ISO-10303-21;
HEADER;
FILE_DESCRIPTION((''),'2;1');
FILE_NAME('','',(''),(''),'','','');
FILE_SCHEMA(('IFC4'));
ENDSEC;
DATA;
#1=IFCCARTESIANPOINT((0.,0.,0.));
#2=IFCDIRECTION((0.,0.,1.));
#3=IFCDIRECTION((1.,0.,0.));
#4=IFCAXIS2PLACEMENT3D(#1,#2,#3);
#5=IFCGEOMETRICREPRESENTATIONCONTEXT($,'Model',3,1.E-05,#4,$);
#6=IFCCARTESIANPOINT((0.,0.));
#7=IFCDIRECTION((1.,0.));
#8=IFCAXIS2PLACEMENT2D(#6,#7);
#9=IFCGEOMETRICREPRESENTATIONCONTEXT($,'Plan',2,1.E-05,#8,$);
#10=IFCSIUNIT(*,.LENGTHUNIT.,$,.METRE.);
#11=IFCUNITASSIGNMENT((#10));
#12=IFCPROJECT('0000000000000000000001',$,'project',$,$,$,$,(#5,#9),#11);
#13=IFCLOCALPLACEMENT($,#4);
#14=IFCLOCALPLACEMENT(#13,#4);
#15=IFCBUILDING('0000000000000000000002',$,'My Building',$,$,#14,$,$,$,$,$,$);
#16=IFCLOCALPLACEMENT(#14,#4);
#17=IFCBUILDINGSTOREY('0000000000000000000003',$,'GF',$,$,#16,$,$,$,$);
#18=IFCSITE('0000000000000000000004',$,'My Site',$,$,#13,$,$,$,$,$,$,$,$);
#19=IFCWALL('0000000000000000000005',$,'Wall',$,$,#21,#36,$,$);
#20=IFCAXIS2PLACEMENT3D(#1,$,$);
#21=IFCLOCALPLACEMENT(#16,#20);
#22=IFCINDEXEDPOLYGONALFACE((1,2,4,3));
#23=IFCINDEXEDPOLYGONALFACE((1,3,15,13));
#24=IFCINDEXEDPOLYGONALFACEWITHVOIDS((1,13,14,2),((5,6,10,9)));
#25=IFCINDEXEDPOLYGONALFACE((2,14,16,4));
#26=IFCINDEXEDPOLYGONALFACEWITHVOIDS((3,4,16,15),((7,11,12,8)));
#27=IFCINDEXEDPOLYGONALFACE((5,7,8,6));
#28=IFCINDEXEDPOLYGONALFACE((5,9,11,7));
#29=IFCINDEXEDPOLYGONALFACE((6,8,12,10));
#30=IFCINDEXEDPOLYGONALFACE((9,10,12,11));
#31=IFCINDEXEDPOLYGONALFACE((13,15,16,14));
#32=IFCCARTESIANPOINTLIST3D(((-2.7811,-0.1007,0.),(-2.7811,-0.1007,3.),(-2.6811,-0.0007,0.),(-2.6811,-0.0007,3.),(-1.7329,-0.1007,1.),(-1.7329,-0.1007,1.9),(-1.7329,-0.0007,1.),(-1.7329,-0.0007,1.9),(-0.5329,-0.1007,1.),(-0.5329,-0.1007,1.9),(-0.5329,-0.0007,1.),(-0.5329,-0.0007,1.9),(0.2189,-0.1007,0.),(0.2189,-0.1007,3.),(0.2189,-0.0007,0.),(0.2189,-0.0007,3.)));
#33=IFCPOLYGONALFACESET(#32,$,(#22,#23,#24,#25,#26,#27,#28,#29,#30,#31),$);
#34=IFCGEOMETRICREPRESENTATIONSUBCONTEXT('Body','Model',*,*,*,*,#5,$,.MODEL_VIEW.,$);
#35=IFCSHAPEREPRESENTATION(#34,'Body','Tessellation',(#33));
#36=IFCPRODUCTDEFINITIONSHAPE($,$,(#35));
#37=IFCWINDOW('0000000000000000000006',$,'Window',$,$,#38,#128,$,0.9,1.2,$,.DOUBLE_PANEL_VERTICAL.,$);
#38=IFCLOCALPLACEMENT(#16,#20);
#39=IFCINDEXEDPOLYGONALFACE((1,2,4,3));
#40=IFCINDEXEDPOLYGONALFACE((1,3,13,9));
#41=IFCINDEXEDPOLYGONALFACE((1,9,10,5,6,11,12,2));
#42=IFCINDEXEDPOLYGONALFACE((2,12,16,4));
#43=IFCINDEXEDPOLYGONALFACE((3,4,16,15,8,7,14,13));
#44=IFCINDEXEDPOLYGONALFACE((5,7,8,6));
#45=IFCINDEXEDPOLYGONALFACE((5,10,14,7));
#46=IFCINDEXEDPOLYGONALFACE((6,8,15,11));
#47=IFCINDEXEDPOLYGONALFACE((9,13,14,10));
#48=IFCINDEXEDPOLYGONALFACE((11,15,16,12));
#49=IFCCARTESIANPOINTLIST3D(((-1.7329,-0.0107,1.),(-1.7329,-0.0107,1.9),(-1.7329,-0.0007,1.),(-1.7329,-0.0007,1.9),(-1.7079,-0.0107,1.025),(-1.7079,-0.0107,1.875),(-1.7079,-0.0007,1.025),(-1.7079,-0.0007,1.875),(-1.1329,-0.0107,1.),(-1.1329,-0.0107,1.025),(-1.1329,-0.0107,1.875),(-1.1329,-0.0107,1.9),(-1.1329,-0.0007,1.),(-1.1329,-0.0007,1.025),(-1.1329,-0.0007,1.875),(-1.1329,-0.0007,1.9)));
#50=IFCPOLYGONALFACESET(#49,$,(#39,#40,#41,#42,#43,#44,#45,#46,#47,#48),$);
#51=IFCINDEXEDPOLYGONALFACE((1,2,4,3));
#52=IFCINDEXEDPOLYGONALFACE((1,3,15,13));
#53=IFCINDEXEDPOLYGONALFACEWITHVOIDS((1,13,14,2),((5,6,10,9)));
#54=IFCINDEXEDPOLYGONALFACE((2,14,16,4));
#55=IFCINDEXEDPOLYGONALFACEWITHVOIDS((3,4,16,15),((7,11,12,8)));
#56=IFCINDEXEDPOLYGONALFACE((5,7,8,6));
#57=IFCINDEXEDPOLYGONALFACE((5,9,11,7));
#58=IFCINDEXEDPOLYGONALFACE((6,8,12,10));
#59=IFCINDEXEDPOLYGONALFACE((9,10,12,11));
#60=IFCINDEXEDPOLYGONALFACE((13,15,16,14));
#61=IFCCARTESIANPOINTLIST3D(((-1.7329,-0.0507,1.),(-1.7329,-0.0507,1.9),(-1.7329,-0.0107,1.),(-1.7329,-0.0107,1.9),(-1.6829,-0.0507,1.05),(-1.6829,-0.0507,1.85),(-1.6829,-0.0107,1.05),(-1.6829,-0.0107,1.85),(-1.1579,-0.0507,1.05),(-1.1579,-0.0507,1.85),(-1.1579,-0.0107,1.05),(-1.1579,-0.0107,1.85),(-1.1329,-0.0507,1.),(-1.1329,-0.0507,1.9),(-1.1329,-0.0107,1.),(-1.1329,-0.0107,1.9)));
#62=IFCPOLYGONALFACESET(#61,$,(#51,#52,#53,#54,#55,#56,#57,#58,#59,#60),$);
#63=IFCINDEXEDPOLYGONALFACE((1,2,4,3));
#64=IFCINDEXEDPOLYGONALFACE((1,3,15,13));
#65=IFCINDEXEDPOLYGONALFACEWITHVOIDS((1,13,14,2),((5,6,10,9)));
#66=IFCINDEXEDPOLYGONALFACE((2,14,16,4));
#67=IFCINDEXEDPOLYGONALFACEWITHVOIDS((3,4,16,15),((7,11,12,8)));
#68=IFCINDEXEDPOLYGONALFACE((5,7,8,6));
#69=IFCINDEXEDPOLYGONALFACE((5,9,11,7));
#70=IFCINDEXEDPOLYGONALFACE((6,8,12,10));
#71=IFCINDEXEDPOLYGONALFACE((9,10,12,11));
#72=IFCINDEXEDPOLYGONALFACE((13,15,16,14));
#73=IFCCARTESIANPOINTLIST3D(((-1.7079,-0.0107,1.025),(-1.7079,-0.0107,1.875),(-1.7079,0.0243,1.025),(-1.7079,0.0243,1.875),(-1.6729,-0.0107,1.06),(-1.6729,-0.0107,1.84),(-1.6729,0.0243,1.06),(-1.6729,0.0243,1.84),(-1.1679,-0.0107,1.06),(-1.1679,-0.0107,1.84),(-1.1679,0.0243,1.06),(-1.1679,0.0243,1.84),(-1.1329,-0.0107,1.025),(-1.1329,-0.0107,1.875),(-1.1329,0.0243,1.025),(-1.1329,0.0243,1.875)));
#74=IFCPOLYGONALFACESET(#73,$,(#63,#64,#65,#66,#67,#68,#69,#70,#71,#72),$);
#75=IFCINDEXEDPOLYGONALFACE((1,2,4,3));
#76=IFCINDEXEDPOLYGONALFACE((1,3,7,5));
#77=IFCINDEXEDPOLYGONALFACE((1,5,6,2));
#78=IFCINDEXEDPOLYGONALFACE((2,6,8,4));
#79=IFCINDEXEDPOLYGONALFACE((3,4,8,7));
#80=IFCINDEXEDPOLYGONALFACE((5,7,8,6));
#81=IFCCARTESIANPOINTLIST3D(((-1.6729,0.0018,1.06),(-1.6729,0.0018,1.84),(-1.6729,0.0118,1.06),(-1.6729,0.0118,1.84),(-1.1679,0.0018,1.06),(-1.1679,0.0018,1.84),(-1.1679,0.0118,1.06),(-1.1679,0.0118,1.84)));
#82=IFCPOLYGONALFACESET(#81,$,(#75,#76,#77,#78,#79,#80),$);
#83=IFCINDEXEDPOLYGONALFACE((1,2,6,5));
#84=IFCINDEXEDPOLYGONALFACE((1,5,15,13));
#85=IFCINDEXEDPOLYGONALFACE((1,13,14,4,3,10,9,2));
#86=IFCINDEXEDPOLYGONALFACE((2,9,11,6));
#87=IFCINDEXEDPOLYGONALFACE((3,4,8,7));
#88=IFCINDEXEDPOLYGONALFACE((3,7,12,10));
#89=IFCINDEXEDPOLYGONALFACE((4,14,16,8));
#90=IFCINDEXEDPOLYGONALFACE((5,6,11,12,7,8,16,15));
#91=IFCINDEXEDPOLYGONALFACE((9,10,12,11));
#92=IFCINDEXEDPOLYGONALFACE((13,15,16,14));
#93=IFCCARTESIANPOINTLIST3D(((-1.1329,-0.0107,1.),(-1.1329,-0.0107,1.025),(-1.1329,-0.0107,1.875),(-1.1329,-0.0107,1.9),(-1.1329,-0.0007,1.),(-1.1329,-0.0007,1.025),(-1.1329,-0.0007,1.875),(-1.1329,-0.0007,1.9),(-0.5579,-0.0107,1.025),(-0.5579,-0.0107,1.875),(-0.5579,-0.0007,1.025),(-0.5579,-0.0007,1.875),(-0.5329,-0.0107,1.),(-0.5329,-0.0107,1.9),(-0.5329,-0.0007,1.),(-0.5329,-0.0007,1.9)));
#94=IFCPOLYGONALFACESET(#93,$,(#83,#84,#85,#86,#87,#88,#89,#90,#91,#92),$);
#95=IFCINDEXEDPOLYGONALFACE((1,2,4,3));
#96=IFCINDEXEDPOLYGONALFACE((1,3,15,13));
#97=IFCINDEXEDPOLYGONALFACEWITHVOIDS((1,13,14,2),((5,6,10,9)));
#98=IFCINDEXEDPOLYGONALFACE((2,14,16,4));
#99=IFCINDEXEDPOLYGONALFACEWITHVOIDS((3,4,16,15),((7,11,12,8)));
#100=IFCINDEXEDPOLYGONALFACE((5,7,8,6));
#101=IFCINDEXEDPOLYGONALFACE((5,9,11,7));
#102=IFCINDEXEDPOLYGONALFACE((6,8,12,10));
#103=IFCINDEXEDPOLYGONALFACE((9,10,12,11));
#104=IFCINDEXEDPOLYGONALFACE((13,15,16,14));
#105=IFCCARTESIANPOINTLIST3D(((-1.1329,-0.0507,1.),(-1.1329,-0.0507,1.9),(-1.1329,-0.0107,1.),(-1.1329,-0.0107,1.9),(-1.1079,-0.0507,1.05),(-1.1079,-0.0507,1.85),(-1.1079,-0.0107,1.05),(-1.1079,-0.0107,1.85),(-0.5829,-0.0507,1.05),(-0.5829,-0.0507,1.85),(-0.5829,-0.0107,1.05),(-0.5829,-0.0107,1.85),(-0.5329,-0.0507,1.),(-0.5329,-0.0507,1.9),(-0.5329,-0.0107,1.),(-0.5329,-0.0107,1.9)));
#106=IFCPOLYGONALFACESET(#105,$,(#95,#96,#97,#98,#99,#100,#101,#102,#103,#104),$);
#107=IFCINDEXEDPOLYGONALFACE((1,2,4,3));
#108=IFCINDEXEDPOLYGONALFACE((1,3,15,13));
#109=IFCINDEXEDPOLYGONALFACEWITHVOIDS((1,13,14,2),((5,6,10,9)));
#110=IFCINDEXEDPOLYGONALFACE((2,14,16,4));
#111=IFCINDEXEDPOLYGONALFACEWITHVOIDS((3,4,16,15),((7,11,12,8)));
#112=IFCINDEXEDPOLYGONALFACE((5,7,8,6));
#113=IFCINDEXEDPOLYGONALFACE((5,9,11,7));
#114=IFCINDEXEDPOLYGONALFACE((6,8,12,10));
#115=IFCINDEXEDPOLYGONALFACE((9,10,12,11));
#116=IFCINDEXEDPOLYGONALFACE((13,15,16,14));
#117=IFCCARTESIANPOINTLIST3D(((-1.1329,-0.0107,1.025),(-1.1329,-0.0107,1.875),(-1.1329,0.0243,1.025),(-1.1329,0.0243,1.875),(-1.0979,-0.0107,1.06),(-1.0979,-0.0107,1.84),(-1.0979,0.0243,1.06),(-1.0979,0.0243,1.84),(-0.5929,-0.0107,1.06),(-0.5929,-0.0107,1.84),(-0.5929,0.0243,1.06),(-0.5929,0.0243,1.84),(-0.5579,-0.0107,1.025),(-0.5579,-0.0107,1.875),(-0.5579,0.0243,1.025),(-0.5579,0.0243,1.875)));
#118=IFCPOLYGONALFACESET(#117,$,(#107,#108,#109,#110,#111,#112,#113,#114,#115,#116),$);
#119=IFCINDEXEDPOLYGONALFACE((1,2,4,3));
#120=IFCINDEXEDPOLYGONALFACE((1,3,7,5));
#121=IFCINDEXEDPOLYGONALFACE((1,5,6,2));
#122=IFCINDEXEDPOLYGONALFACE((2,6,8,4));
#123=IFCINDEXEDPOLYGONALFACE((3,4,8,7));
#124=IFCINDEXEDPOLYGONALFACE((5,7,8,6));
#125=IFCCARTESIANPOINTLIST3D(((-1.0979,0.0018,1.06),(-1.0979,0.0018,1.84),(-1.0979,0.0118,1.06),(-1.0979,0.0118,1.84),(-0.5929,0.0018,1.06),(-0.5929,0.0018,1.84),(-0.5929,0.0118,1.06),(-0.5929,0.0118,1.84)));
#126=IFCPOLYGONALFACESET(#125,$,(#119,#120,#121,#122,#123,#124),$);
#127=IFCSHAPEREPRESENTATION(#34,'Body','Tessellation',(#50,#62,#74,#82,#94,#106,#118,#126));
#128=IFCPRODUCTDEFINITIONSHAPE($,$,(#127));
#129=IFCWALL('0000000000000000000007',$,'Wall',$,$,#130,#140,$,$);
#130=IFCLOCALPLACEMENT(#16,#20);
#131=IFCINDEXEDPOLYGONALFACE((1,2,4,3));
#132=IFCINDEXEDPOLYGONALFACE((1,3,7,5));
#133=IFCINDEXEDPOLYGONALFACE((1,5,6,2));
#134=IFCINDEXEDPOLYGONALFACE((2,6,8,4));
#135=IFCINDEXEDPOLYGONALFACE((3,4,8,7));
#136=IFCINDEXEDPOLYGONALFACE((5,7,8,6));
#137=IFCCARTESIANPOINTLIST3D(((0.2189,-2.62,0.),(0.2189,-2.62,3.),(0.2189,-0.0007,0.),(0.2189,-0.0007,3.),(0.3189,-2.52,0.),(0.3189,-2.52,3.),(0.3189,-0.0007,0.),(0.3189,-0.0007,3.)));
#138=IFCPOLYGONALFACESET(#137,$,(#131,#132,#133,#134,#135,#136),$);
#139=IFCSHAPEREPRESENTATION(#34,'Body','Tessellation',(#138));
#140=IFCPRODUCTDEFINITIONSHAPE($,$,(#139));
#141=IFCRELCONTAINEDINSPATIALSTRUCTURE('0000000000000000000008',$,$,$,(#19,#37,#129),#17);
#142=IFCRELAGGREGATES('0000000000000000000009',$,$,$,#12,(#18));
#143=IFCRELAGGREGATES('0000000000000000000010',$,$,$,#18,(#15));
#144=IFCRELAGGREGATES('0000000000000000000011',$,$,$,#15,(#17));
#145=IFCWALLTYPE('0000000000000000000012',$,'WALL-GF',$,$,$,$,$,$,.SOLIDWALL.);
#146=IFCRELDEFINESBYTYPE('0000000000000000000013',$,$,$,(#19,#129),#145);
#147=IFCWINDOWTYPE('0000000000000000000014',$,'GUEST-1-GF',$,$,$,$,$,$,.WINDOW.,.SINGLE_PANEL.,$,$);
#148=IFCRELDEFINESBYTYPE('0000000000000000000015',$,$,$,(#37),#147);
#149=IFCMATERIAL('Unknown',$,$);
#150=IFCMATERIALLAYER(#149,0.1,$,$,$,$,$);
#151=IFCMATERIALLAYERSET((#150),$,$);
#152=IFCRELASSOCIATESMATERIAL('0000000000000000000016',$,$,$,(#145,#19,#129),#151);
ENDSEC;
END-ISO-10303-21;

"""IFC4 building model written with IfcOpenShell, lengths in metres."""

from ifc_helpers import new_model, entity, si_unit, frame, origin_with_axes, origin_2d_with_axis, place, context, subcontext, project, spatial, line, indexed_curve, outline, extrude, shape, source, transform, mapped, material, layer, layer_set, layer_usage, type_object, type_shapes, element, fill, save


model = new_model("IFC4")

# Units and contexts
model_context = context("Model", 3, precision=1e-05, world=origin_with_axes())
plan_context = context("Plan", 2, precision=1e-05, world=origin_2d_with_axis())
body_context_1 = subcontext(model_context, "Body", "Model", "MODEL_VIEW")
body_context_2 = subcontext(plan_context, "Body", "Plan", "PLAN_VIEW")
ifc_project = project(units=[si_unit("LENGTHUNIT", "METRE")], contexts=[model_context, plan_context])

# Site, building, storey
site_placement = place(None, origin_with_axes())
site = spatial("IfcSite", under=ifc_project, at=site_placement, Name="My Site")
building_placement = place(site_placement, origin_with_axes())
building = spatial("IfcBuilding", under=site, at=building_placement, Name="My Building")
storey_placement = place(building_placement, origin_with_axes())
storey = spatial("IfcBuildingStorey", under=building, at=storey_placement, Name="GF")

# Shared definitions
ifc_material = material(Name="Unknown")

# Shared definitions
ifc_layer_1 = layer(ifc_material, 0.1)
ifc_layer_set_1 = layer_set([ifc_layer_1])
wall_type = type_object("IfcWallType", Name="WALL-GF", PredefinedType="SOLIDWALL", material=ifc_layer_set_1)

# Wall, opening, window
ifc_layer_usage_1 = layer_usage(ifc_layer_set_1, "AXIS2", "POSITIVE", 0.0)
wall_1_placement = place(storey_placement, frame((-2.7811, -0.1007, 0.0), z_axis=(0.0, 0.0, 1.0), x_axis=(1.0, 0.0, 0.0)))
wall_1 = element("IfcWall", 1, at=wall_1_placement, inside=storey, type_object=wall_type, material=ifc_layer_usage_1, Name="Wall", context=body_context_1, shape_type="SweptSolid", body=[
    extrude(outline(indexed_curve([(0.0, 0.0), (0.1, 0.1), (3.0, 0.1), (3.0, 0.0)], segments=[line(1, 2, 3, 4, 1)])), origin_with_axes(), (0.0, 0.0, 1.0), 3.0),
])
shared_shape_1 = source(origin_with_axes(), body_context_1, "Body", "SweptSolid", [
    extrude(outline(indexed_curve([(0.0, 0.0), (1.2, 0.0), (1.2, 0.9), (0.0, 0.9)], segments=[line(1, 2, 3, 4, 1)])), frame((0.0, -0.6, 0.0), z_axis=(0.0, -1.0, 0.0), x_axis=(1.0, 0.0, 0.0)), (0.0, 0.0, -1.0), 1.2),
])
opening_1_placement = place(wall_1_placement, frame((1.0481, 0.0, 1.0), z_axis=(0.0, 0.0, 1.0), x_axis=(1.0, 0.0, 0.0)))
opening_1 = element("IfcOpeningElement", 2, at=opening_1_placement, cuts=wall_1, PredefinedType="OPENING", context=body_context_1, shape_type="MappedRepresentation", body=[
    mapped(shared_shape_1, transform((0.0, 0.0, 0.0), x_axis=(1.0, 0.0, 0.0), y_axis=(0.0, 1.0, 0.0), z_axis=(0.0, 0.0, 1.0), scale=1.0)),
])
window_type_1 = type_object("IfcWindowType", Name="GUEST-1-GF", PartitioningType="SINGLE_PANEL", PredefinedType="WINDOW")
shared_shape_2 = source(origin_with_axes(), body_context_1, "Body", "SweptSolid", [
    extrude(outline(indexed_curve([(0.6, 0.0), (0.0, 0.0), (0.0, 0.9), (0.6, 0.9), (0.6, 0.875), (0.025, 0.875), (0.025, 0.025), (0.6, 0.025)], segments=[line(1, 2, 3, 4, 5, 6, 7, 8, 1)])), frame((0.0, 0.09, 0.0), z_axis=(0.0, -1.0, 0.0), x_axis=(1.0, 0.0, 0.0)), (0.0, 0.0, -1.0), 0.01),
    extrude(outline(indexed_curve([(0.0, 0.0), (0.6, 0.0), (0.6, 0.9), (0.0, 0.9)], segments=[line(1, 2, 3, 4, 1)]), holes=[indexed_curve([(0.05, 0.05), (0.575, 0.05), (0.575, 0.85), (0.05, 0.85)], segments=[line(1, 2, 3, 4, 1)])]), frame((0.0, 0.05, 0.0), z_axis=(0.0, -1.0, 0.0), x_axis=(1.0, 0.0, 0.0)), (0.0, 0.0, -1.0), 0.04),
    extrude(outline(indexed_curve([(0.0, 0.0), (0.575, 0.0), (0.575, 0.85), (0.0, 0.85)], segments=[line(1, 2, 3, 4, 1)]), holes=[indexed_curve([(0.035, 0.035), (0.54, 0.035), (0.54, 0.815), (0.035, 0.815)], segments=[line(1, 2, 3, 4, 1)])]), frame((0.025, 0.09, 0.025), z_axis=(0.0, -1.0, 0.0), x_axis=(1.0, 0.0, 0.0)), (0.0, 0.0, -1.0), 0.035),
    extrude(outline(indexed_curve([(0.035, 0.035), (0.54, 0.035), (0.54, 0.815), (0.035, 0.815)], segments=[line(1, 2, 3, 4, 1)])), frame((0.025, 0.1025, 0.025), z_axis=(0.0, -1.0, 0.0), x_axis=(1.0, 0.0, 0.0)), (0.0, 0.0, -1.0), 0.01),
    extrude(outline(indexed_curve([(0.0, 0.9), (0.6, 0.9), (0.6, 0.0), (0.0, 0.0), (0.0, 0.025), (0.575, 0.025), (0.575, 0.875), (0.0, 0.875)], segments=[line(1, 2, 3, 4, 5, 6, 7, 8, 1)])), frame((0.6, 0.09, 0.0), z_axis=(0.0, -1.0, 0.0), x_axis=(1.0, 0.0, 0.0)), (0.0, 0.0, -1.0), 0.01),
    extrude(outline(indexed_curve([(0.0, 0.0), (0.6, 0.0), (0.6, 0.9), (0.0, 0.9)], segments=[line(1, 2, 3, 4, 1)]), holes=[indexed_curve([(0.025, 0.05), (0.55, 0.05), (0.55, 0.85), (0.025, 0.85)], segments=[line(1, 2, 3, 4, 1)])]), frame((0.6, 0.05, 0.0), z_axis=(0.0, -1.0, 0.0), x_axis=(1.0, 0.0, 0.0)), (0.0, 0.0, -1.0), 0.04),
    extrude(outline(indexed_curve([(0.0, 0.0), (0.575, 0.0), (0.575, 0.85), (0.0, 0.85)], segments=[line(1, 2, 3, 4, 1)]), holes=[indexed_curve([(0.035, 0.035), (0.54, 0.035), (0.54, 0.815), (0.035, 0.815)], segments=[line(1, 2, 3, 4, 1)])]), frame((0.6, 0.09, 0.025), z_axis=(0.0, -1.0, 0.0), x_axis=(1.0, 0.0, 0.0)), (0.0, 0.0, -1.0), 0.035),
    extrude(outline(indexed_curve([(0.035, 0.035), (0.54, 0.035), (0.54, 0.815), (0.035, 0.815)], segments=[line(1, 2, 3, 4, 1)])), frame((0.6, 0.1025, 0.025), z_axis=(0.0, -1.0, 0.0), x_axis=(1.0, 0.0, 0.0)), (0.0, 0.0, -1.0), 0.01),
])
shared_shape_3 = source(origin_with_axes(), body_context_2, "Body", "Curve2D", [
    entity("IfcIndexedPolyCurve", entity("IfcCartesianPointList2D", [[0.05, 0.05], [0.575, 0.05]])),
    entity("IfcIndexedPolyCurve", entity("IfcCartesianPointList2D", [[0.0, 0.1], [0.025, 0.1], [0.025, 0.09], [0.05, 0.09], [0.05, 0.05], [0.0, 0.05]]), [entity("IfcLineIndex", [1, 2, 3, 4, 5, 6, 1])]),
    entity("IfcIndexedPolyCurve", entity("IfcCartesianPointList2D", [[0.6, 0.1], [0.6, 0.1], [0.6, 0.09], [0.575, 0.09], [0.575, 0.05], [0.6, 0.05]])),
    entity("IfcIndexedPolyCurve", entity("IfcCartesianPointList2D", [[0.025, 0.09], [0.06, 0.09], [0.06, 0.125], [0.025, 0.125]]), [entity("IfcLineIndex", [1, 2, 3, 4, 1])]),
    entity("IfcIndexedPolyCurve", entity("IfcCartesianPointList2D", [[0.6, 0.09], [0.565, 0.09], [0.565, 0.125], [0.6, 0.125]]), [entity("IfcLineIndex", [1, 2, 3, 4, 1])]),
    entity("IfcIndexedPolyCurve", entity("IfcCartesianPointList2D", [[0.06, 0.09], [0.565, 0.09]])),
    entity("IfcIndexedPolyCurve", entity("IfcCartesianPointList2D", [[0.06, 0.125], [0.565, 0.125]])),
    entity("IfcIndexedPolyCurve", entity("IfcCartesianPointList2D", [[0.06, 0.1075], [0.565, 0.1075]])),
    entity("IfcIndexedPolyCurve", entity("IfcCartesianPointList2D", [[0.625, 0.05], [1.15, 0.05]])),
    entity("IfcIndexedPolyCurve", entity("IfcCartesianPointList2D", [[0.6, 0.1], [0.6, 0.1], [0.6, 0.09], [0.625, 0.09], [0.625, 0.05], [0.6, 0.05]])),
    entity("IfcIndexedPolyCurve", entity("IfcCartesianPointList2D", [[1.2, 0.1], [1.175, 0.1], [1.175, 0.09], [1.15, 0.09], [1.15, 0.05], [1.2, 0.05]]), [entity("IfcLineIndex", [1, 2, 3, 4, 5, 6, 1])]),
    entity("IfcIndexedPolyCurve", entity("IfcCartesianPointList2D", [[0.6, 0.09], [0.635, 0.09], [0.635, 0.125], [0.6, 0.125]]), [entity("IfcLineIndex", [1, 2, 3, 4, 1])]),
    entity("IfcIndexedPolyCurve", entity("IfcCartesianPointList2D", [[1.175, 0.09], [1.14, 0.09], [1.14, 0.125], [1.175, 0.125]]), [entity("IfcLineIndex", [1, 2, 3, 4, 1])]),
    entity("IfcIndexedPolyCurve", entity("IfcCartesianPointList2D", [[0.635, 0.09], [1.14, 0.09]])),
    entity("IfcIndexedPolyCurve", entity("IfcCartesianPointList2D", [[0.635, 0.125], [1.14, 0.125]])),
    entity("IfcIndexedPolyCurve", entity("IfcCartesianPointList2D", [[0.635, 0.1075], [1.14, 0.1075]])),
])
type_shapes(window_type_1, [shared_shape_2, shared_shape_3])
window_1_placement = place(opening_1_placement, origin_with_axes())
window_1 = element("IfcWindow", 3, at=window_1_placement, inside=storey, type_object=window_type_1, Name="Window", OverallHeight=0.9, OverallWidth=1.2, PartitioningType="DOUBLE_PANEL_VERTICAL", shapes=[
    shape(body_context_1, "Body", "MappedRepresentation", [mapped(shared_shape_2, transform((0.0, 0.0, 0.0), x_axis=(1.0, 0.0, 0.0), y_axis=(0.0, 1.0, 0.0), z_axis=(0.0, 0.0, 1.0), scale=1.0))]),
    shape(body_context_2, "Body", "MappedRepresentation", [mapped(shared_shape_3, transform((0.0, 0.0, 0.0), x_axis=(1.0, 0.0, 0.0), y_axis=(0.0, 1.0, 0.0), z_axis=(0.0, 0.0, 1.0), scale=1.0))]),
])
fill(opening_1, window_1)

# Wall
ifc_layer_usage_2 = layer_usage(ifc_layer_set_1, "AXIS2", "POSITIVE", 0.0)
wall_2_placement = place(storey_placement, frame((0.2189, -0.0007, 0.0), z_axis=(0.0, 0.0, 1.0), x_axis=(0.0, -1.0, 0.0)))
element("IfcWall", 4, at=wall_2_placement, inside=storey, type_object=wall_type, material=ifc_layer_usage_2, Name="Wall", context=body_context_1, shape_type="SweptSolid", body=[
    extrude(outline(indexed_curve([(0.0, 0.0), (0.0, 0.1), (2.5193, 0.1), (2.6193, 0.0)], segments=[line(1, 2, 3, 4, 1)])), origin_with_axes(), (0.0, 0.0, 1.0), 3.0),
])

save(model, "model.ifc")
